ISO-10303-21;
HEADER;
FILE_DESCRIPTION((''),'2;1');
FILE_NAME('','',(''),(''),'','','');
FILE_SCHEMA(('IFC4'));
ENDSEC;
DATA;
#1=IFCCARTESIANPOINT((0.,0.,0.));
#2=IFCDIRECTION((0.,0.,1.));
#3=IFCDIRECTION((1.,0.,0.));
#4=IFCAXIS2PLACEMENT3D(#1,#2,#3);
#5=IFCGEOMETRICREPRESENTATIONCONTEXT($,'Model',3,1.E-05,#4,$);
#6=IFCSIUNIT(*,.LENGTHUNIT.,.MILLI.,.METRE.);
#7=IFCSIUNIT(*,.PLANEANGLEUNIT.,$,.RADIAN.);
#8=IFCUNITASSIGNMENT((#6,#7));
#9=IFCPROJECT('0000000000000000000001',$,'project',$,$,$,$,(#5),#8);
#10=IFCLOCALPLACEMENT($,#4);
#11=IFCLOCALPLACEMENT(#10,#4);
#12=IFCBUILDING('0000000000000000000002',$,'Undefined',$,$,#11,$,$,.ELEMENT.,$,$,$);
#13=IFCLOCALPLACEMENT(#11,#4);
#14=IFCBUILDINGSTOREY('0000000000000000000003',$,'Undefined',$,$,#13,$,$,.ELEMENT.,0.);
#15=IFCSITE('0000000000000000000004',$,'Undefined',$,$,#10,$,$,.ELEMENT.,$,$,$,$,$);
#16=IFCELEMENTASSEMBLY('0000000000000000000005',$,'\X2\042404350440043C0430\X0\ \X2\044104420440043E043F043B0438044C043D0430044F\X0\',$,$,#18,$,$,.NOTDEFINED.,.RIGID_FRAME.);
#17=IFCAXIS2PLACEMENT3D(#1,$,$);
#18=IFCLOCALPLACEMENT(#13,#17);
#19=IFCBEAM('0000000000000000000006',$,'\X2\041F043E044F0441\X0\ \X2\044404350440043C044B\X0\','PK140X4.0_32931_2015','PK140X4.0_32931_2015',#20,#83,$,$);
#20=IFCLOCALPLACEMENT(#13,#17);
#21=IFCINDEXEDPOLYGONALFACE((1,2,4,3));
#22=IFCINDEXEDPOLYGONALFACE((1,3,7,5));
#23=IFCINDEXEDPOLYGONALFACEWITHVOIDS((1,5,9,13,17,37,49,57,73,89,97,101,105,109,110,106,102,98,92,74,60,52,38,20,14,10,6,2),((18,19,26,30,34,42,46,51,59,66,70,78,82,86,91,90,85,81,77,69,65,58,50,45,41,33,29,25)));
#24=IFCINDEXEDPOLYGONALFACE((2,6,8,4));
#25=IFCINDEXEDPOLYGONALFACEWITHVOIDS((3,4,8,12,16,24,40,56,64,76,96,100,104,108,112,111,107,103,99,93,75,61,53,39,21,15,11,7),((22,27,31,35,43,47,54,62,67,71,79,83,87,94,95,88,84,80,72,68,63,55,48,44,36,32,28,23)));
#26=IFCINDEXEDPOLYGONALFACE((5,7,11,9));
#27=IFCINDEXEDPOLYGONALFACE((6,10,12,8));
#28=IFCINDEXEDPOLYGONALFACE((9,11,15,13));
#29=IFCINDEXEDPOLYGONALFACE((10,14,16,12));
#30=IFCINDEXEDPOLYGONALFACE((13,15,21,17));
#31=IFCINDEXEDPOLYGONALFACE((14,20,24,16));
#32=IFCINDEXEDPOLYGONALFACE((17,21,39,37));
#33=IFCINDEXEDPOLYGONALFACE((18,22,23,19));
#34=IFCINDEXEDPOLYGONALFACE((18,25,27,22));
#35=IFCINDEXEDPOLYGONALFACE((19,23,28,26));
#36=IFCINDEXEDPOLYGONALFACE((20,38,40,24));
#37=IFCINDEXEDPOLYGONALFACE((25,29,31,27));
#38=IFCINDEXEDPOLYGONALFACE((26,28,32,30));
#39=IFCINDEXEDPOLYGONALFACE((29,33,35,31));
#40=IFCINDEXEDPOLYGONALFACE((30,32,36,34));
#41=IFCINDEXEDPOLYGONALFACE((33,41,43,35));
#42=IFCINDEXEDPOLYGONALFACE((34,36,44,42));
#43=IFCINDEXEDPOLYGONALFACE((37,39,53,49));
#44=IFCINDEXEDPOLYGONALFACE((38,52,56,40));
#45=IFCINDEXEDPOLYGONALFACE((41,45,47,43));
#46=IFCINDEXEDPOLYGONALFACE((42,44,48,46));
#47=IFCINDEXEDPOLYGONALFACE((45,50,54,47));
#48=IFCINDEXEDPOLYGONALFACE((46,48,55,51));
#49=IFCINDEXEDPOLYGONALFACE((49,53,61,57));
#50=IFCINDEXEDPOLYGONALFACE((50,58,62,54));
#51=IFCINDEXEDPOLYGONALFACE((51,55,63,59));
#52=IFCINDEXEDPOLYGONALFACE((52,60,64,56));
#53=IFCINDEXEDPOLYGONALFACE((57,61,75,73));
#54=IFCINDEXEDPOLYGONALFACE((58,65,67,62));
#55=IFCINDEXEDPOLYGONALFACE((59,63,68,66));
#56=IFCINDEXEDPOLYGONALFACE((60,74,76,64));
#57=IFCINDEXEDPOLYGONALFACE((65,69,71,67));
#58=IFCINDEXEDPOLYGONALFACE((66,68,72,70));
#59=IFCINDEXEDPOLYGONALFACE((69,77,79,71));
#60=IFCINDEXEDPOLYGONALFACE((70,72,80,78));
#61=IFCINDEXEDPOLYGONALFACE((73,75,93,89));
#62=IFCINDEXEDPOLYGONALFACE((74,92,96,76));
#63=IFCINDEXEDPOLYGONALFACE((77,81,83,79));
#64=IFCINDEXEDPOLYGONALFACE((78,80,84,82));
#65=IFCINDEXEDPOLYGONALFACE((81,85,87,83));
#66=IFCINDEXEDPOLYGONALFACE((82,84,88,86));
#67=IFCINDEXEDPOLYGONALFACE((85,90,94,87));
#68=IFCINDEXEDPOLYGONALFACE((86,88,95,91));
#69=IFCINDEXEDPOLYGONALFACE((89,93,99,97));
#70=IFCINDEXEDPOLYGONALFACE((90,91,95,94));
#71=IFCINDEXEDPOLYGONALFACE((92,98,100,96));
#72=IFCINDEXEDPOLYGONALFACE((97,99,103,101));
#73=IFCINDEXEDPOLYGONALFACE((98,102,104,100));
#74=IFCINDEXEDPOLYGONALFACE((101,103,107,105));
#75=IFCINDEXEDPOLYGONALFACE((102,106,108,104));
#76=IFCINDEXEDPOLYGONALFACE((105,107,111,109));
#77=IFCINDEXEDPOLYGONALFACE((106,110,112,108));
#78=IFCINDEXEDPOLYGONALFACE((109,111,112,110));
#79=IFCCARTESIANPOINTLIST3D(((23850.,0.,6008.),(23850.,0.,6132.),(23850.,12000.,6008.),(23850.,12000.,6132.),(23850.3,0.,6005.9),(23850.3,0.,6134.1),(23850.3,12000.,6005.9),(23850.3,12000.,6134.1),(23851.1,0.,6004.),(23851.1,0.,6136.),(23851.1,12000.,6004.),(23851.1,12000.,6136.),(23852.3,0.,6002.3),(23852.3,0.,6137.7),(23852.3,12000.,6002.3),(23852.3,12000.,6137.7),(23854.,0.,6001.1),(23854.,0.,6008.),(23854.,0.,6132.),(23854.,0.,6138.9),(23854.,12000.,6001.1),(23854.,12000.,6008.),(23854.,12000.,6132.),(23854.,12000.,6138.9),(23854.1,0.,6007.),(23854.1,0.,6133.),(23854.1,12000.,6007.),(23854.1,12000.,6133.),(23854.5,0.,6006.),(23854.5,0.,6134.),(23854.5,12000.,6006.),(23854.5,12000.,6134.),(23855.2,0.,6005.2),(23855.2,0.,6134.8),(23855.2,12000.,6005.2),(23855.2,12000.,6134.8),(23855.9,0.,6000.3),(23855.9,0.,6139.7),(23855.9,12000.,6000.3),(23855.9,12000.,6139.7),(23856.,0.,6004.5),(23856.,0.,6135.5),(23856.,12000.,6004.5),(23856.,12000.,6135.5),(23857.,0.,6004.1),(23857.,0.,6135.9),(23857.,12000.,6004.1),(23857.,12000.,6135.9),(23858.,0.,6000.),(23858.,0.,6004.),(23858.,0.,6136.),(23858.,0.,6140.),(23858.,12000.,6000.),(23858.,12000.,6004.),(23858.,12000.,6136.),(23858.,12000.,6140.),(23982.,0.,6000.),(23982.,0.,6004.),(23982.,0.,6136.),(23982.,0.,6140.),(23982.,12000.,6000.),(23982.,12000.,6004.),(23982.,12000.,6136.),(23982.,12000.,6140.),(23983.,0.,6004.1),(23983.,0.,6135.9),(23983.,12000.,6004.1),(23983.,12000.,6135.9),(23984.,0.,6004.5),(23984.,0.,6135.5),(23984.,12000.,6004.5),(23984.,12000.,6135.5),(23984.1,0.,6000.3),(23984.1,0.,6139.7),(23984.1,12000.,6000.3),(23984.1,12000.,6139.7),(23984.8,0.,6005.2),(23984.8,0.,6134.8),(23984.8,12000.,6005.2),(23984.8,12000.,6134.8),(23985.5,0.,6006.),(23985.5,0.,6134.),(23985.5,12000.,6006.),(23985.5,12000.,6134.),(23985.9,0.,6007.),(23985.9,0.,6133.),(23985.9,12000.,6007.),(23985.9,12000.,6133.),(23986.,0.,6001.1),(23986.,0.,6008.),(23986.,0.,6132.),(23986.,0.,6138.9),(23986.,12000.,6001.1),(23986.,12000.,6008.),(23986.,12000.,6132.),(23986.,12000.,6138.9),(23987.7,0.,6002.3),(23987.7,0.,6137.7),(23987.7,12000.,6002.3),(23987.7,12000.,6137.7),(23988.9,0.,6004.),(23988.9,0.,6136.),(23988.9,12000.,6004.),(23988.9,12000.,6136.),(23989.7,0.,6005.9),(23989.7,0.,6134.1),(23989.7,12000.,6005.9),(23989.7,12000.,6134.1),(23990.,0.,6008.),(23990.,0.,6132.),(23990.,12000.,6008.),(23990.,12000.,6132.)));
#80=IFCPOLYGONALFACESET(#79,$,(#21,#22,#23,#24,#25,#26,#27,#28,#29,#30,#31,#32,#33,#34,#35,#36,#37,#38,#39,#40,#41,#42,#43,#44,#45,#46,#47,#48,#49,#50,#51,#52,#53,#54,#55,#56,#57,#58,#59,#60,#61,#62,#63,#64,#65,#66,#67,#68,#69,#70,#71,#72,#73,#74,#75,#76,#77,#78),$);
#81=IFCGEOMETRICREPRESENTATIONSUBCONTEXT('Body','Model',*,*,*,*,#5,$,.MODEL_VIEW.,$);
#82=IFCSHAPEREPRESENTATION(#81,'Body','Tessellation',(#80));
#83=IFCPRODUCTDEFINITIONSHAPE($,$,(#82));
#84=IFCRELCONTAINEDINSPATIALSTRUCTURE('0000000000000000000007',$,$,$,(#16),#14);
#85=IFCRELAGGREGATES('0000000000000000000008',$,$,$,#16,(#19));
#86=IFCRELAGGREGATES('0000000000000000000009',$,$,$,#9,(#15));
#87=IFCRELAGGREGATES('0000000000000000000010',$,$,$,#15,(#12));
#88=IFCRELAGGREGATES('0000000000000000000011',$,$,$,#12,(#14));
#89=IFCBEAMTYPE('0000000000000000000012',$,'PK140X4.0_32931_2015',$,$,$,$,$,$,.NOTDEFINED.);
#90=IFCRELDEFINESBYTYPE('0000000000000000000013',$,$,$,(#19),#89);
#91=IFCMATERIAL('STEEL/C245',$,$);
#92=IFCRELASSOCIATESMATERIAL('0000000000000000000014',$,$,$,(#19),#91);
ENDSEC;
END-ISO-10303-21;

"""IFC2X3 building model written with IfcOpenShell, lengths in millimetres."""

from ifc_helpers import new_model, si_unit, frame, origin_with_axes, origin_2d_with_axis, place, context, subcontext, project, spatial, hollow_rectangle, extrude, material, type_object, element, aggregate, save


model = new_model("IFC2X3")

# Units and contexts
model_context = context("Model", 3, precision=1e-05, world=origin_with_axes())
body_context = subcontext(model_context, "Body", "Model", "MODEL_VIEW")
ifc_project = project(units=[si_unit("LENGTHUNIT", "METRE", prefix="MILLI"), si_unit("PLANEANGLEUNIT", "RADIAN")], contexts=[model_context])

# Site, building, storey
site_placement = place(None, origin_with_axes())
site = spatial("IfcSite", under=ifc_project, at=site_placement, Name="Undefined", CompositionType="ELEMENT")
building_placement = place(site_placement, origin_with_axes())
building = spatial("IfcBuilding", under=site, at=building_placement, Name="Undefined", CompositionType="ELEMENT")
storey_placement = place(building_placement, origin_with_axes())
storey = spatial("IfcBuildingStorey", under=building, at=storey_placement, Name="Undefined", CompositionType="ELEMENT", Elevation=0.0)

# Shared definitions
ifc_material = material(Name="STEEL/C245")

# Element assembly
assembly_1_placement = place(storey_placement, origin_with_axes())
assembly_1 = element("IfcElementAssembly", 1, at=assembly_1_placement, inside=storey, Name="Ферма строплиьная", AssemblyPlace="NOTDEFINED", PredefinedType="RIGID_FRAME")

# Beam
beam_type_1 = type_object("IfcBeamType", Name="PK140X4.0_32931_2015", PredefinedType="NOTDEFINED")
beam_1_placement = place(assembly_1_placement, frame((23920.0, 0.0, 6070.0), z_axis=(0.0, 0.0, 1.0), x_axis=(0.0, 1.0, 0.0)))
beam_1 = element("IfcBeam", 2, at=beam_1_placement, type_object=beam_type_1, material=ifc_material, Name="Пояс фермы", Description="PK140X4.0_32931_2015", ObjectType="PK140X4.0_32931_2015", context=body_context, shape_type="SweptSolid", body=[
    extrude(hollow_rectangle(XDim=140.0, YDim=140.0, WallThickness=4.0, InnerFilletRadius=4.0, OuterFilletRadius=8.0, at=origin_2d_with_axis()), frame((12000.0, 0.0, 0.0), z_axis=(-1.0, 0.0, 0.0), x_axis=(0.0, -1.0, 0.0)), (0.0, 0.0, 1.0), 12000.0),
])
aggregate(assembly_1, [beam_1])

save(model, "model.ifc")
